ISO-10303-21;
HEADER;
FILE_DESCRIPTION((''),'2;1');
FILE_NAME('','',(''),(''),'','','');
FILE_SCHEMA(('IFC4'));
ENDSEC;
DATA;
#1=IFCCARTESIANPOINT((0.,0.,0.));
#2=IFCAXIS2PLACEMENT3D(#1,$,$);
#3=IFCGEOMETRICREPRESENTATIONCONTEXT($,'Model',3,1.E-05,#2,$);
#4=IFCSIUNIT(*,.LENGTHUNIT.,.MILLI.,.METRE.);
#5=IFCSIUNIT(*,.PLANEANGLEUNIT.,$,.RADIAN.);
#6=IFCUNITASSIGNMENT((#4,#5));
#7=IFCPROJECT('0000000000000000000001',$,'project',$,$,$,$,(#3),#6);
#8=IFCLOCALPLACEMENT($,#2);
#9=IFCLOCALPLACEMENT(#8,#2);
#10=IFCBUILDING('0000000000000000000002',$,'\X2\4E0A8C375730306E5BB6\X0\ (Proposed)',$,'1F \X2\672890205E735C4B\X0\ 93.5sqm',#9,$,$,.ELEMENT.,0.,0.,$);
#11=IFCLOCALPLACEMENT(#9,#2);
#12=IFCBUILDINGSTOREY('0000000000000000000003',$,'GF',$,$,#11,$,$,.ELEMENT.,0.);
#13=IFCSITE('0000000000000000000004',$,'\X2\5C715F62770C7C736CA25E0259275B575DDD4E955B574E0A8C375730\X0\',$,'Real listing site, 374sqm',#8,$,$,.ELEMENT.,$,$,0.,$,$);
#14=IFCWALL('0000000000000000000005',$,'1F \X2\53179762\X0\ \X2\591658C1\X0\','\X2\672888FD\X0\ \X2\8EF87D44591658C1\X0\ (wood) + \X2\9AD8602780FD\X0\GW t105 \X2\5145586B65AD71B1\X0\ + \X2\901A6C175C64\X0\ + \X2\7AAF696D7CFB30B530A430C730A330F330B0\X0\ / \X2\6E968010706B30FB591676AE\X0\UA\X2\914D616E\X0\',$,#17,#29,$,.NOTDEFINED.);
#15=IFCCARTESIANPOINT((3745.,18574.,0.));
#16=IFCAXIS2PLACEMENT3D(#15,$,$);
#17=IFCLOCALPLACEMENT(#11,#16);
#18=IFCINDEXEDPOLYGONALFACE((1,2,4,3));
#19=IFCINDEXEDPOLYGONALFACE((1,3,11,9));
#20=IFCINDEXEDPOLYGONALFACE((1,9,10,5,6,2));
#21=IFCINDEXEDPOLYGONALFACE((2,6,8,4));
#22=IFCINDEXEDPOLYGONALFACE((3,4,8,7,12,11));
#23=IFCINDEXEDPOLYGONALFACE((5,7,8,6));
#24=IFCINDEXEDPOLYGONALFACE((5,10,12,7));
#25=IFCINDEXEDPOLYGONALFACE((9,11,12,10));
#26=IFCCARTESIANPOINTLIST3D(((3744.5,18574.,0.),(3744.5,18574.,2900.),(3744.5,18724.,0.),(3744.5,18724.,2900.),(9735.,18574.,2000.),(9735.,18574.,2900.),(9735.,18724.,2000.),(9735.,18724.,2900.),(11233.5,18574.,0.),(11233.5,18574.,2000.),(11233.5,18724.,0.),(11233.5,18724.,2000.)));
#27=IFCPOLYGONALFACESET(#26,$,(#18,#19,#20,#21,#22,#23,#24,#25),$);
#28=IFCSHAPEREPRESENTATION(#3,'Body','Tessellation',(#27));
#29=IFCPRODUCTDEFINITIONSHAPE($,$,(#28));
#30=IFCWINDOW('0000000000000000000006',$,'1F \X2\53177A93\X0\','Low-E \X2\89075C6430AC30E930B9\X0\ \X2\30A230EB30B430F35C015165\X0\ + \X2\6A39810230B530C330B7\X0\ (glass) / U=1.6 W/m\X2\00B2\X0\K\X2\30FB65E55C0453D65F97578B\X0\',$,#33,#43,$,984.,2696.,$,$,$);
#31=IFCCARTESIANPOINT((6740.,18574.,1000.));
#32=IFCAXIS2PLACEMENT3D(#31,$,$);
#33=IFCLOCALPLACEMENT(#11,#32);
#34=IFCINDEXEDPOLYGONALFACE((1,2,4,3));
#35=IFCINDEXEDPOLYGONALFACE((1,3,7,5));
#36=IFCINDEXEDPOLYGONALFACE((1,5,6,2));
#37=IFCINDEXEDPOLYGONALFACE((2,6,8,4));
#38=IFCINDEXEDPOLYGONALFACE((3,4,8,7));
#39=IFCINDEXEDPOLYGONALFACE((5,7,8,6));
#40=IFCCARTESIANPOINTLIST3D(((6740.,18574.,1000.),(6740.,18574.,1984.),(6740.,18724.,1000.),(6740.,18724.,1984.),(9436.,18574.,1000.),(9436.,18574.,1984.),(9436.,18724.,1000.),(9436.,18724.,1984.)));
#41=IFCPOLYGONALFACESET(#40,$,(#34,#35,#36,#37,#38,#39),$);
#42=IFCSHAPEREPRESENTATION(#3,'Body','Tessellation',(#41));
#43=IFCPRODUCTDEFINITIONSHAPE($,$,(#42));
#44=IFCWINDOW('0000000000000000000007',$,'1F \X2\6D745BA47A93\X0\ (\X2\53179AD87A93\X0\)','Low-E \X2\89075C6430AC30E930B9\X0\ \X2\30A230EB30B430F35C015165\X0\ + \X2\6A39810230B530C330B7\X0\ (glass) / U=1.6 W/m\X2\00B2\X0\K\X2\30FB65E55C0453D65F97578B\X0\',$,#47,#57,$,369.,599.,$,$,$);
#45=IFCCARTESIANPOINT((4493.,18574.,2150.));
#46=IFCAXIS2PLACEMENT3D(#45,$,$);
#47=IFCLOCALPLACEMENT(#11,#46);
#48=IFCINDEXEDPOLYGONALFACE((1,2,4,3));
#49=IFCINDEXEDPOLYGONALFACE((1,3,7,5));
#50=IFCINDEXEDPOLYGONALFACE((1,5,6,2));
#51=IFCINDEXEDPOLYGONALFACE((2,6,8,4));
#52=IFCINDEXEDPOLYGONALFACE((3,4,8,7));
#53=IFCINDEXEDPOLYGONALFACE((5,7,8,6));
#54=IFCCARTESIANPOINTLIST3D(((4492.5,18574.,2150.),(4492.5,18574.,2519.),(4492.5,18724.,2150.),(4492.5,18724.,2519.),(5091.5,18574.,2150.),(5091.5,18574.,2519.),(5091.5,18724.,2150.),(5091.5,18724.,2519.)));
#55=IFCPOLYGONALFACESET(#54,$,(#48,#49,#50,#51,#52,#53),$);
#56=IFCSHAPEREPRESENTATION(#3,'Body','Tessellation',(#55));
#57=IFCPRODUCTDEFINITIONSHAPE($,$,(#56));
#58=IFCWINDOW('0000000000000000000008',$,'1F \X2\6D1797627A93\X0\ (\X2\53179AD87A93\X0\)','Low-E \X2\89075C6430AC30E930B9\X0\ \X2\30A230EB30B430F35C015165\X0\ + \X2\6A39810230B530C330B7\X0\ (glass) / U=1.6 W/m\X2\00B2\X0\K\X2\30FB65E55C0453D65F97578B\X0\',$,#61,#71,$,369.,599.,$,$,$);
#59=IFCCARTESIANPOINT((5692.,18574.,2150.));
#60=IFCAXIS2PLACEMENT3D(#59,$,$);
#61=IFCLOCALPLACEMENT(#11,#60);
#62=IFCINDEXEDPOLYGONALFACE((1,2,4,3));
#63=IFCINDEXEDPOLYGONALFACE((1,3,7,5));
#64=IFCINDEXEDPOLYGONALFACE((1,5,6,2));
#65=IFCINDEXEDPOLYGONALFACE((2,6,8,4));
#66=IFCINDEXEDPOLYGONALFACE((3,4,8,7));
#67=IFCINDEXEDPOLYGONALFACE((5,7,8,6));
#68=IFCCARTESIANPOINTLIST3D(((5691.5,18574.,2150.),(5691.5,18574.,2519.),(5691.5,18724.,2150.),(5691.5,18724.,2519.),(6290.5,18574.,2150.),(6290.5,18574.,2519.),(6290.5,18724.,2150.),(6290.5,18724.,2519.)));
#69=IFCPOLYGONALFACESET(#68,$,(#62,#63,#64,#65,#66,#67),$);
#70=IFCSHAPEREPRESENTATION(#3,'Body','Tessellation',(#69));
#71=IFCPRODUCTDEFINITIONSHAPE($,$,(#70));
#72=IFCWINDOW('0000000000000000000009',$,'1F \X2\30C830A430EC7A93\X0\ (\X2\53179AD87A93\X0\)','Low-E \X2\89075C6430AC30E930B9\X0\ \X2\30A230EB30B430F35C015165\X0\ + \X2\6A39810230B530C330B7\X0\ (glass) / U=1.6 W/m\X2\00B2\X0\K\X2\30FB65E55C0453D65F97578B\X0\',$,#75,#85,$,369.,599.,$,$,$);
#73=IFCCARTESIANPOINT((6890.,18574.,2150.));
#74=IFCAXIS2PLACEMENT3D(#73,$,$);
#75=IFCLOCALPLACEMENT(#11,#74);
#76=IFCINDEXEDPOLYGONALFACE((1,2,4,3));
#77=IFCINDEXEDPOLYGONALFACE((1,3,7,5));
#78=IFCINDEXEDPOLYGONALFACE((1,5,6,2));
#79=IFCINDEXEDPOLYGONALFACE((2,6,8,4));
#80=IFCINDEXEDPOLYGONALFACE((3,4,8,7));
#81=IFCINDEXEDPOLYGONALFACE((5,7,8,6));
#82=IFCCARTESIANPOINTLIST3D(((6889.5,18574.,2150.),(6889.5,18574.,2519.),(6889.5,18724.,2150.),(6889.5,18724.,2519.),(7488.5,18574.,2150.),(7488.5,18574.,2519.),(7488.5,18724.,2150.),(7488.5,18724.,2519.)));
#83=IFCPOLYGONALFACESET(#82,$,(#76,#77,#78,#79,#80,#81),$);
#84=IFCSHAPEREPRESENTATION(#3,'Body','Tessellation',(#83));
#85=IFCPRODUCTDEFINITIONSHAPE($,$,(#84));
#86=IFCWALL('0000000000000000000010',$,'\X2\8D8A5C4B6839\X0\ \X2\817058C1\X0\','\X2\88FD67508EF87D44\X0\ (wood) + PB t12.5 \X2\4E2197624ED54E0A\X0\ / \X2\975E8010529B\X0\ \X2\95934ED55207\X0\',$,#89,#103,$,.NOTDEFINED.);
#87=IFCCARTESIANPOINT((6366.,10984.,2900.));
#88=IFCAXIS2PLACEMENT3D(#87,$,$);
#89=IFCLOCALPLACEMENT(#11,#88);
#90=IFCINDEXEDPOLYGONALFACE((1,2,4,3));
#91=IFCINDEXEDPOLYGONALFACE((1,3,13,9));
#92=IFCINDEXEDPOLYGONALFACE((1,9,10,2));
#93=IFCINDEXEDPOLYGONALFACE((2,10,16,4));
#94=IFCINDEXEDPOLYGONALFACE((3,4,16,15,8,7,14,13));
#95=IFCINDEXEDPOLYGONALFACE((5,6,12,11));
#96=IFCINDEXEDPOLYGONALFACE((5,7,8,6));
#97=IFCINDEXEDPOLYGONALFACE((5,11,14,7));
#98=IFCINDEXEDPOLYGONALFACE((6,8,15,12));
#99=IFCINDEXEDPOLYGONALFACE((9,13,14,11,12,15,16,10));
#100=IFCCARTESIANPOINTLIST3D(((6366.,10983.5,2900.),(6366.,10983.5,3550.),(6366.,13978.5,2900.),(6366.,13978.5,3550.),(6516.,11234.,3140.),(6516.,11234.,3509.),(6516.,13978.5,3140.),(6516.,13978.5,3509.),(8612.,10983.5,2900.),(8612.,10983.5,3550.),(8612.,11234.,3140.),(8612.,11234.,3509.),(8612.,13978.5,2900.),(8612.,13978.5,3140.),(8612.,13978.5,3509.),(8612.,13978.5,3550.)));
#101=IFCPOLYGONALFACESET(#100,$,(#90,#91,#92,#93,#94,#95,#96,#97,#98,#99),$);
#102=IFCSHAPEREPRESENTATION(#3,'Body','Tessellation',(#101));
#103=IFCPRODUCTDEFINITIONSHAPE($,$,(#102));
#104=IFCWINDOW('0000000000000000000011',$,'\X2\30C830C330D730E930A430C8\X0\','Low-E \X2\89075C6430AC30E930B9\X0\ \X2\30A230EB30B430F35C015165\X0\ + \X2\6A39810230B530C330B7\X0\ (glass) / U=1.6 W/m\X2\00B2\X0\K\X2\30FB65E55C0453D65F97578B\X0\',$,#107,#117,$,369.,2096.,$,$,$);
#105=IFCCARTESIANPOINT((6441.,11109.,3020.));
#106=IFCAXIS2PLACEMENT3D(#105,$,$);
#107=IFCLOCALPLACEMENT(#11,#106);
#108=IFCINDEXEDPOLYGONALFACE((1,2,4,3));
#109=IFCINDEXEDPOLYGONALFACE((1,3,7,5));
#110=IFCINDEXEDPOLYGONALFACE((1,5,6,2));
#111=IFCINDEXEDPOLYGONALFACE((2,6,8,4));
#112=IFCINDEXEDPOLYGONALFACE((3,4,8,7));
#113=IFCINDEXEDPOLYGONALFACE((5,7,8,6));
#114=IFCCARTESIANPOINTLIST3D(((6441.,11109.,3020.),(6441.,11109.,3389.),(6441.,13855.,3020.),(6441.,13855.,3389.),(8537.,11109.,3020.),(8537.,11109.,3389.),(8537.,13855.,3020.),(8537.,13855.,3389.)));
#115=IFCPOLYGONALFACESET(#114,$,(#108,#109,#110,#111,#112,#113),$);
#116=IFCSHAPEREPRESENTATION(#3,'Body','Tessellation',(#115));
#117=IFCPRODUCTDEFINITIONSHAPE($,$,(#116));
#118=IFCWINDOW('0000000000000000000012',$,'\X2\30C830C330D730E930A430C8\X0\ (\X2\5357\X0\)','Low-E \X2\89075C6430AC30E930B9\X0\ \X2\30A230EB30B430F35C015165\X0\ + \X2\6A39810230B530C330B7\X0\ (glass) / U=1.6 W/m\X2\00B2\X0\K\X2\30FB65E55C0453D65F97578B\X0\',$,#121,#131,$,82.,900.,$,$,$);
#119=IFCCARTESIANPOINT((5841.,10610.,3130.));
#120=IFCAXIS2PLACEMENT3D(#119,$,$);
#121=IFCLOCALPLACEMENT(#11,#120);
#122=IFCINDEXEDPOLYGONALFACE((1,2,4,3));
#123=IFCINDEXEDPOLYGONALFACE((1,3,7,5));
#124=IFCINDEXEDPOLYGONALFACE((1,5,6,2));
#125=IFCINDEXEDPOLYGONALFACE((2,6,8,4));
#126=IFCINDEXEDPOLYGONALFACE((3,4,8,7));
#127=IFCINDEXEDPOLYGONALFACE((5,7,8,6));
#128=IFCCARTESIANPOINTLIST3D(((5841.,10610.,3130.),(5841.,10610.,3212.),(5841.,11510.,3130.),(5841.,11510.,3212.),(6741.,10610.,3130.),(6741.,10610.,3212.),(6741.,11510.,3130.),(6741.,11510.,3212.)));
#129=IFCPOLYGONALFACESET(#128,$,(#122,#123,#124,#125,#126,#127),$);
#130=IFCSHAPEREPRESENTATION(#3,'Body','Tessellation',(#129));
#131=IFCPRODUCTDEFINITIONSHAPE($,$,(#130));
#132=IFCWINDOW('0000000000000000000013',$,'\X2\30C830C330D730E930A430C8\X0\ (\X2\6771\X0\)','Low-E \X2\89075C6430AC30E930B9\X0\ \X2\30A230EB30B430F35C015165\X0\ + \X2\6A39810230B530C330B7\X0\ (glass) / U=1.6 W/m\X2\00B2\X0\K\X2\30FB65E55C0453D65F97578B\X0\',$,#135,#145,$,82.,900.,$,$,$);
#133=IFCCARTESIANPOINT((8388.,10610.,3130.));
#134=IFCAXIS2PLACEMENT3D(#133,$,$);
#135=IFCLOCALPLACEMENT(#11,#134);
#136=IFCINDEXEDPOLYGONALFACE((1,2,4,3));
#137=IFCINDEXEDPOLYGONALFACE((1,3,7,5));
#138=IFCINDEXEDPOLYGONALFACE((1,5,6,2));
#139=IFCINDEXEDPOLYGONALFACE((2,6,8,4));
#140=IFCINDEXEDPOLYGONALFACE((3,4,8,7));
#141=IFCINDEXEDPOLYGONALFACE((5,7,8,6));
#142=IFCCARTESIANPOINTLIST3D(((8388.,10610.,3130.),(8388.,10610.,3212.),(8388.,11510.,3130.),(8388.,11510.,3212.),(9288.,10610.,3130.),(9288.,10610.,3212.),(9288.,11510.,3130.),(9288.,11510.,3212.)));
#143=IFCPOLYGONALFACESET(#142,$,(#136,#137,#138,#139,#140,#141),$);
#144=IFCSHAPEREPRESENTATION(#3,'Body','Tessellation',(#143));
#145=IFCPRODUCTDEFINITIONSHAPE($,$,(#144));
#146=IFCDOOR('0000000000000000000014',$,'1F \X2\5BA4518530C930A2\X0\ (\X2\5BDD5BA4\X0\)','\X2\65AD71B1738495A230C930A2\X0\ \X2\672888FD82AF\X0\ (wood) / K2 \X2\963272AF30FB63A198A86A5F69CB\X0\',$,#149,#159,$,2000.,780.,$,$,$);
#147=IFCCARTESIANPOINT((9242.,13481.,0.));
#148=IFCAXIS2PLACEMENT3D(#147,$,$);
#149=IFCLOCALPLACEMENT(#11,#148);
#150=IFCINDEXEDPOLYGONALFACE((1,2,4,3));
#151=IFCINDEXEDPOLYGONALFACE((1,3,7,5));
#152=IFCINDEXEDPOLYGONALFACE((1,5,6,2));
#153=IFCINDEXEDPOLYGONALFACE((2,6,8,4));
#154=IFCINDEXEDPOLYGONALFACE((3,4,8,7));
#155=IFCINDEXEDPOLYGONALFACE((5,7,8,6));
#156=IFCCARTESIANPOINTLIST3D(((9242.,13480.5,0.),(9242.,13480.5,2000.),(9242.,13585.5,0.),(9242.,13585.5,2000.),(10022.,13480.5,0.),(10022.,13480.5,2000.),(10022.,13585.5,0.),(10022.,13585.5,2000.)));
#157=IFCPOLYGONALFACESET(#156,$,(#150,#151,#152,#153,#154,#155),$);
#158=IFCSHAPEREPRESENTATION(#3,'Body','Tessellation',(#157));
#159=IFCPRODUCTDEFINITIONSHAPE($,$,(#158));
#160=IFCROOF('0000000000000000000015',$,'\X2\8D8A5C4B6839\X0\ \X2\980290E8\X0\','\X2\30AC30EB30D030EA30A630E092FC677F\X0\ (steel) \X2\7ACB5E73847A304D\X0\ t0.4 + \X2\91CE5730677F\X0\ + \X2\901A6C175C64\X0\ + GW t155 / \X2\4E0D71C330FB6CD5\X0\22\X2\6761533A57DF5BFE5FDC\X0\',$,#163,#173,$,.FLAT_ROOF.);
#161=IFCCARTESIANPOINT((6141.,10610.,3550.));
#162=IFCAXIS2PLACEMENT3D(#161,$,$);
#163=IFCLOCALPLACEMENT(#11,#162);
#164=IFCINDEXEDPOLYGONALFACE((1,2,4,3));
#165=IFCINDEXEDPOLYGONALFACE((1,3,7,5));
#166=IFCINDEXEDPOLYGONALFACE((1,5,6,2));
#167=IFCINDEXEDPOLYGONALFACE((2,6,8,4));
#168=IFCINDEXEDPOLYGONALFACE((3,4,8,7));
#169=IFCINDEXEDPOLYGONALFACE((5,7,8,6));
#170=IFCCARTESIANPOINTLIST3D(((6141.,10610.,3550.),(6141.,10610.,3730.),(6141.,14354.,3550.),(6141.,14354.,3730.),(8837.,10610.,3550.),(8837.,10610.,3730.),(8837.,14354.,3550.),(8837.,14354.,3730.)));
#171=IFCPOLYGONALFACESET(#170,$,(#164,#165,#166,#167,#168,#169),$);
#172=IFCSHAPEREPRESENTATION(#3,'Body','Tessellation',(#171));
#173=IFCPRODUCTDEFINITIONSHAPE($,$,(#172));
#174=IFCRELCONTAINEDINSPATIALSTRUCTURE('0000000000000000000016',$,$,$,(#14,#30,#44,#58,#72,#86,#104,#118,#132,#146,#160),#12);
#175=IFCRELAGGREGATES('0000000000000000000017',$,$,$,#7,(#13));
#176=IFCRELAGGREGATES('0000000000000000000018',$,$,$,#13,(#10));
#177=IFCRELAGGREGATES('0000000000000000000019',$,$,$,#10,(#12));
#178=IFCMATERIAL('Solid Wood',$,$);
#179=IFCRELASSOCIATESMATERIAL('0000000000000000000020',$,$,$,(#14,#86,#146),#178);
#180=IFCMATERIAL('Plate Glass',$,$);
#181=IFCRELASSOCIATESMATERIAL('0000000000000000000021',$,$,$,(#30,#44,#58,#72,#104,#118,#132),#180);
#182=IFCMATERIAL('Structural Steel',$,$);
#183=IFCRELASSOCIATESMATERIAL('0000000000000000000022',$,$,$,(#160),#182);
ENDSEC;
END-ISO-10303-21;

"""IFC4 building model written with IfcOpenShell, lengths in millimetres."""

from ifc_helpers import new_model, si_unit, frame, frame_2d, origin, place, context, project, spatial, rectangle, extrude, material, element, fill, save


model = new_model("IFC4")

# Units and contexts
model_context = context("Model", 3, precision=1e-05, world=origin())
ifc_project = project(units=[si_unit("LENGTHUNIT", "METRE", prefix="MILLI"), si_unit("PLANEANGLEUNIT", "RADIAN")], contexts=[model_context])

# Site, building, storey
site_placement = place(None, origin())
site = spatial("IfcSite", under=ifc_project, at=site_placement, Name="山形県米沢市大字川井字上谷地", ObjectType="Real listing site, 374sqm", CompositionType="ELEMENT", RefElevation=0.0)
building_placement = place(site_placement, origin())
building = spatial("IfcBuilding", under=site, at=building_placement, Name="上谷地の家 (Proposed)", ObjectType="1F 木造平屋 93.5sqm", CompositionType="ELEMENT", ElevationOfRefHeight=0.0, ElevationOfTerrain=0.0)
storey_placement = place(building_placement, origin())
storey = spatial("IfcBuildingStorey", under=building, at=storey_placement, Name="GF", CompositionType="ELEMENT", Elevation=0.0)

# Shared definitions
ifc_material_1 = material(Name="Solid Wood")

# Wall, openings, windows
wall_1_placement = place(storey_placement, frame((3745.0, 18574.0, 0.0)))
wall_1 = element("IfcWall", 1, at=wall_1_placement, inside=storey, material=ifc_material_1, Name="1F 北面 外壁", Description="木製 軸組外壁 (wood) + 高性能GW t105 充填断熱 + 通気層 + 窯業系サイディング / 準耐火・外皮UA配慮", PredefinedType="NOTDEFINED", context=model_context, shape_type="SweptSolid", body=[
    extrude(rectangle(XDim=7489.0, YDim=150.0, at=frame_2d((3744.0, 75.0))), frame((3745.0, 18574.0, 0.0)), (0.0, 0.0, 1.0), 2900.0),
])
opening_1_placement = place(storey_placement, frame((6740.0, 18574.0, 1000.0)))
opening_1 = element("IfcOpeningElement", 2, at=opening_1_placement, cuts=wall_1, PredefinedType="NOTDEFINED", context=model_context, shape_type="SweptSolid", body=[
    extrude(rectangle(XDim=2696.0, YDim=150.0, at=frame_2d((1348.0, 75.0))), frame((6740.0, 18574.0, 1000.0)), (0.0, 0.0, 1.0), 984.0),
])
opening_2_placement = place(storey_placement, frame((4493.0, 18574.0, 2150.0)))
opening_2 = element("IfcOpeningElement", 3, at=opening_2_placement, cuts=wall_1, PredefinedType="NOTDEFINED", context=model_context, shape_type="SweptSolid", body=[
    extrude(rectangle(XDim=599.0, YDim=150.0, at=frame_2d((299.0, 75.0))), frame((4493.0, 18574.0, 2150.0)), (0.0, 0.0, 1.0), 369.0),
])
opening_3_placement = place(storey_placement, frame((5692.0, 18574.0, 2150.0)))
opening_3 = element("IfcOpeningElement", 4, at=opening_3_placement, cuts=wall_1, PredefinedType="NOTDEFINED", context=model_context, shape_type="SweptSolid", body=[
    extrude(rectangle(XDim=599.0, YDim=150.0, at=frame_2d((299.0, 75.0))), frame((5692.0, 18574.0, 2150.0)), (0.0, 0.0, 1.0), 369.0),
])
opening_4_placement = place(storey_placement, frame((6890.0, 18574.0, 2150.0)))
opening_4 = element("IfcOpeningElement", 5, at=opening_4_placement, cuts=wall_1, PredefinedType="NOTDEFINED", context=model_context, shape_type="SweptSolid", body=[
    extrude(rectangle(XDim=599.0, YDim=150.0, at=frame_2d((299.0, 75.0))), frame((6890.0, 18574.0, 2150.0)), (0.0, 0.0, 1.0), 369.0),
])
ifc_material_2 = material(Name="Plate Glass")
window_1_placement = place(storey_placement, frame((6740.0, 18574.0, 1000.0)))
window_1 = element("IfcWindow", 6, at=window_1_placement, inside=storey, material=ifc_material_2, Name="1F 北窓", Description="Low-E 複層ガラス アルゴン封入 + 樹脂サッシ (glass) / U=1.6 W/m²K・日射取得型", OverallHeight=984.0, OverallWidth=2696.0, context=model_context, shape_type="SweptSolid", body=[
    extrude(rectangle(XDim=2696.0, YDim=150.0, at=frame_2d((1348.0, 75.0))), frame((6740.0, 18574.0, 1000.0)), (0.0, 0.0, 1.0), 984.0),
])
fill(opening_1, window_1)
window_2_placement = place(storey_placement, frame((4493.0, 18574.0, 2150.0)))
window_2 = element("IfcWindow", 7, at=window_2_placement, inside=storey, material=ifc_material_2, Name="1F 浴室窓 (北高窓)", Description="Low-E 複層ガラス アルゴン封入 + 樹脂サッシ (glass) / U=1.6 W/m²K・日射取得型", OverallHeight=369.0, OverallWidth=599.0, context=model_context, shape_type="SweptSolid", body=[
    extrude(rectangle(XDim=599.0, YDim=150.0, at=frame_2d((299.0, 75.0))), frame((4493.0, 18574.0, 2150.0)), (0.0, 0.0, 1.0), 369.0),
])
fill(opening_2, window_2)
window_3_placement = place(storey_placement, frame((5692.0, 18574.0, 2150.0)))
window_3 = element("IfcWindow", 8, at=window_3_placement, inside=storey, material=ifc_material_2, Name="1F 洗面窓 (北高窓)", Description="Low-E 複層ガラス アルゴン封入 + 樹脂サッシ (glass) / U=1.6 W/m²K・日射取得型", OverallHeight=369.0, OverallWidth=599.0, context=model_context, shape_type="SweptSolid", body=[
    extrude(rectangle(XDim=599.0, YDim=150.0, at=frame_2d((299.0, 75.0))), frame((5692.0, 18574.0, 2150.0)), (0.0, 0.0, 1.0), 369.0),
])
fill(opening_3, window_3)
window_4_placement = place(storey_placement, frame((6890.0, 18574.0, 2150.0)))
window_4 = element("IfcWindow", 9, at=window_4_placement, inside=storey, material=ifc_material_2, Name="1F トイレ窓 (北高窓)", Description="Low-E 複層ガラス アルゴン封入 + 樹脂サッシ (glass) / U=1.6 W/m²K・日射取得型", OverallHeight=369.0, OverallWidth=599.0, context=model_context, shape_type="SweptSolid", body=[
    extrude(rectangle(XDim=599.0, YDim=150.0, at=frame_2d((299.0, 75.0))), frame((6890.0, 18574.0, 2150.0)), (0.0, 0.0, 1.0), 369.0),
])
fill(opening_4, window_4)

# Wall, openings, windows
wall_2_placement = place(storey_placement, frame((6366.0, 10984.0, 2900.0)))
wall_2 = element("IfcWall", 10, at=wall_2_placement, inside=storey, material=ifc_material_1, Name="越屋根 腰壁", Description="製材軸組 (wood) + PB t12.5 両面仕上 / 非耐力 間仕切", PredefinedType="NOTDEFINED", context=model_context, shape_type="SweptSolid", body=[
    extrude(rectangle(XDim=2246.0, YDim=2995.0, at=frame_2d((1123.0, 1497.0))), frame((6366.0, 10984.0, 2900.0)), (0.0, 0.0, 1.0), 650.0),
])
opening_5_placement = place(storey_placement, frame((6441.0, 11109.0, 3020.0)))
opening_5 = element("IfcOpeningElement", 11, at=opening_5_placement, cuts=wall_2, PredefinedType="NOTDEFINED", context=model_context, shape_type="SweptSolid", body=[
    extrude(rectangle(XDim=2096.0, YDim=2746.0, at=frame_2d((1048.0, 1373.0))), frame((6441.0, 11109.0, 3020.0)), (0.0, 0.0, 1.0), 369.0),
])
opening_6_placement = place(storey_placement, frame((5841.0, 10610.0, 3130.0)))
opening_6 = element("IfcOpeningElement", 12, at=opening_6_placement, cuts=wall_2, PredefinedType="NOTDEFINED", context=model_context, shape_type="SweptSolid", body=[
    extrude(rectangle(XDim=900.0, YDim=900.0, at=frame_2d((450.0, 450.0))), frame((5841.0, 10610.0, 3130.0)), (0.0, 0.0, 1.0), 82.0),
])
opening_7_placement = place(storey_placement, frame((8388.0, 10610.0, 3130.0)))
opening_7 = element("IfcOpeningElement", 13, at=opening_7_placement, cuts=wall_2, PredefinedType="NOTDEFINED", context=model_context, shape_type="SweptSolid", body=[
    extrude(rectangle(XDim=900.0, YDim=900.0, at=frame_2d((450.0, 450.0))), frame((8388.0, 10610.0, 3130.0)), (0.0, 0.0, 1.0), 82.0),
])
window_5_placement = place(storey_placement, frame((6441.0, 11109.0, 3020.0)))
window_5 = element("IfcWindow", 14, at=window_5_placement, inside=storey, material=ifc_material_2, Name="トップライト", Description="Low-E 複層ガラス アルゴン封入 + 樹脂サッシ (glass) / U=1.6 W/m²K・日射取得型", OverallHeight=369.0, OverallWidth=2096.0, context=model_context, shape_type="SweptSolid", body=[
    extrude(rectangle(XDim=2096.0, YDim=2746.0, at=frame_2d((1048.0, 1373.0))), frame((6441.0, 11109.0, 3020.0)), (0.0, 0.0, 1.0), 369.0),
])
fill(opening_5, window_5)
window_6_placement = place(storey_placement, frame((5841.0, 10610.0, 3130.0)))
window_6 = element("IfcWindow", 15, at=window_6_placement, inside=storey, material=ifc_material_2, Name="トップライト (南)", Description="Low-E 複層ガラス アルゴン封入 + 樹脂サッシ (glass) / U=1.6 W/m²K・日射取得型", OverallHeight=82.0, OverallWidth=900.0, context=model_context, shape_type="SweptSolid", body=[
    extrude(rectangle(XDim=900.0, YDim=900.0, at=frame_2d((450.0, 450.0))), frame((5841.0, 10610.0, 3130.0)), (0.0, 0.0, 1.0), 82.0),
])
fill(opening_6, window_6)
window_7_placement = place(storey_placement, frame((8388.0, 10610.0, 3130.0)))
window_7 = element("IfcWindow", 16, at=window_7_placement, inside=storey, material=ifc_material_2, Name="トップライト (東)", Description="Low-E 複層ガラス アルゴン封入 + 樹脂サッシ (glass) / U=1.6 W/m²K・日射取得型", OverallHeight=82.0, OverallWidth=900.0, context=model_context, shape_type="SweptSolid", body=[
    extrude(rectangle(XDim=900.0, YDim=900.0, at=frame_2d((450.0, 450.0))), frame((8388.0, 10610.0, 3130.0)), (0.0, 0.0, 1.0), 82.0),
])
fill(opening_7, window_7)

# Door
door_1_placement = place(storey_placement, frame((9242.0, 13481.0, 0.0)))
element("IfcDoor", 17, at=door_1_placement, inside=storey, material=ifc_material_1, Name="1F 室内ドア (寝室)", Description="断熱玄関ドア 木製芯 (wood) / K2 防犯・採風機構", OverallHeight=2000.0, OverallWidth=780.0, context=model_context, shape_type="SweptSolid", body=[
    extrude(rectangle(XDim=780.0, YDim=105.0, at=frame_2d((390.0, 52.0))), frame((9242.0, 13481.0, 0.0)), (0.0, 0.0, 1.0), 2000.0),
])

# Roof
ifc_material_3 = material(Name="Structural Steel")
roof_placement = place(storey_placement, frame((6141.0, 10610.0, 3550.0)))
element("IfcRoof", 18, at=roof_placement, inside=storey, material=ifc_material_3, Name="越屋根 頂部", Description="ガルバリウム鋼板 (steel) 立平葺き t0.4 + 野地板 + 通気層 + GW t155 / 不燃・法22条区域対応", PredefinedType="FLAT_ROOF", context=model_context, shape_type="SweptSolid", body=[
    extrude(rectangle(XDim=2696.0, YDim=3744.0, at=frame_2d((1348.0, 1872.0))), frame((6141.0, 10610.0, 3550.0)), (0.0, 0.0, 1.0), 180.0),
])

save(model, "model.ifc")
